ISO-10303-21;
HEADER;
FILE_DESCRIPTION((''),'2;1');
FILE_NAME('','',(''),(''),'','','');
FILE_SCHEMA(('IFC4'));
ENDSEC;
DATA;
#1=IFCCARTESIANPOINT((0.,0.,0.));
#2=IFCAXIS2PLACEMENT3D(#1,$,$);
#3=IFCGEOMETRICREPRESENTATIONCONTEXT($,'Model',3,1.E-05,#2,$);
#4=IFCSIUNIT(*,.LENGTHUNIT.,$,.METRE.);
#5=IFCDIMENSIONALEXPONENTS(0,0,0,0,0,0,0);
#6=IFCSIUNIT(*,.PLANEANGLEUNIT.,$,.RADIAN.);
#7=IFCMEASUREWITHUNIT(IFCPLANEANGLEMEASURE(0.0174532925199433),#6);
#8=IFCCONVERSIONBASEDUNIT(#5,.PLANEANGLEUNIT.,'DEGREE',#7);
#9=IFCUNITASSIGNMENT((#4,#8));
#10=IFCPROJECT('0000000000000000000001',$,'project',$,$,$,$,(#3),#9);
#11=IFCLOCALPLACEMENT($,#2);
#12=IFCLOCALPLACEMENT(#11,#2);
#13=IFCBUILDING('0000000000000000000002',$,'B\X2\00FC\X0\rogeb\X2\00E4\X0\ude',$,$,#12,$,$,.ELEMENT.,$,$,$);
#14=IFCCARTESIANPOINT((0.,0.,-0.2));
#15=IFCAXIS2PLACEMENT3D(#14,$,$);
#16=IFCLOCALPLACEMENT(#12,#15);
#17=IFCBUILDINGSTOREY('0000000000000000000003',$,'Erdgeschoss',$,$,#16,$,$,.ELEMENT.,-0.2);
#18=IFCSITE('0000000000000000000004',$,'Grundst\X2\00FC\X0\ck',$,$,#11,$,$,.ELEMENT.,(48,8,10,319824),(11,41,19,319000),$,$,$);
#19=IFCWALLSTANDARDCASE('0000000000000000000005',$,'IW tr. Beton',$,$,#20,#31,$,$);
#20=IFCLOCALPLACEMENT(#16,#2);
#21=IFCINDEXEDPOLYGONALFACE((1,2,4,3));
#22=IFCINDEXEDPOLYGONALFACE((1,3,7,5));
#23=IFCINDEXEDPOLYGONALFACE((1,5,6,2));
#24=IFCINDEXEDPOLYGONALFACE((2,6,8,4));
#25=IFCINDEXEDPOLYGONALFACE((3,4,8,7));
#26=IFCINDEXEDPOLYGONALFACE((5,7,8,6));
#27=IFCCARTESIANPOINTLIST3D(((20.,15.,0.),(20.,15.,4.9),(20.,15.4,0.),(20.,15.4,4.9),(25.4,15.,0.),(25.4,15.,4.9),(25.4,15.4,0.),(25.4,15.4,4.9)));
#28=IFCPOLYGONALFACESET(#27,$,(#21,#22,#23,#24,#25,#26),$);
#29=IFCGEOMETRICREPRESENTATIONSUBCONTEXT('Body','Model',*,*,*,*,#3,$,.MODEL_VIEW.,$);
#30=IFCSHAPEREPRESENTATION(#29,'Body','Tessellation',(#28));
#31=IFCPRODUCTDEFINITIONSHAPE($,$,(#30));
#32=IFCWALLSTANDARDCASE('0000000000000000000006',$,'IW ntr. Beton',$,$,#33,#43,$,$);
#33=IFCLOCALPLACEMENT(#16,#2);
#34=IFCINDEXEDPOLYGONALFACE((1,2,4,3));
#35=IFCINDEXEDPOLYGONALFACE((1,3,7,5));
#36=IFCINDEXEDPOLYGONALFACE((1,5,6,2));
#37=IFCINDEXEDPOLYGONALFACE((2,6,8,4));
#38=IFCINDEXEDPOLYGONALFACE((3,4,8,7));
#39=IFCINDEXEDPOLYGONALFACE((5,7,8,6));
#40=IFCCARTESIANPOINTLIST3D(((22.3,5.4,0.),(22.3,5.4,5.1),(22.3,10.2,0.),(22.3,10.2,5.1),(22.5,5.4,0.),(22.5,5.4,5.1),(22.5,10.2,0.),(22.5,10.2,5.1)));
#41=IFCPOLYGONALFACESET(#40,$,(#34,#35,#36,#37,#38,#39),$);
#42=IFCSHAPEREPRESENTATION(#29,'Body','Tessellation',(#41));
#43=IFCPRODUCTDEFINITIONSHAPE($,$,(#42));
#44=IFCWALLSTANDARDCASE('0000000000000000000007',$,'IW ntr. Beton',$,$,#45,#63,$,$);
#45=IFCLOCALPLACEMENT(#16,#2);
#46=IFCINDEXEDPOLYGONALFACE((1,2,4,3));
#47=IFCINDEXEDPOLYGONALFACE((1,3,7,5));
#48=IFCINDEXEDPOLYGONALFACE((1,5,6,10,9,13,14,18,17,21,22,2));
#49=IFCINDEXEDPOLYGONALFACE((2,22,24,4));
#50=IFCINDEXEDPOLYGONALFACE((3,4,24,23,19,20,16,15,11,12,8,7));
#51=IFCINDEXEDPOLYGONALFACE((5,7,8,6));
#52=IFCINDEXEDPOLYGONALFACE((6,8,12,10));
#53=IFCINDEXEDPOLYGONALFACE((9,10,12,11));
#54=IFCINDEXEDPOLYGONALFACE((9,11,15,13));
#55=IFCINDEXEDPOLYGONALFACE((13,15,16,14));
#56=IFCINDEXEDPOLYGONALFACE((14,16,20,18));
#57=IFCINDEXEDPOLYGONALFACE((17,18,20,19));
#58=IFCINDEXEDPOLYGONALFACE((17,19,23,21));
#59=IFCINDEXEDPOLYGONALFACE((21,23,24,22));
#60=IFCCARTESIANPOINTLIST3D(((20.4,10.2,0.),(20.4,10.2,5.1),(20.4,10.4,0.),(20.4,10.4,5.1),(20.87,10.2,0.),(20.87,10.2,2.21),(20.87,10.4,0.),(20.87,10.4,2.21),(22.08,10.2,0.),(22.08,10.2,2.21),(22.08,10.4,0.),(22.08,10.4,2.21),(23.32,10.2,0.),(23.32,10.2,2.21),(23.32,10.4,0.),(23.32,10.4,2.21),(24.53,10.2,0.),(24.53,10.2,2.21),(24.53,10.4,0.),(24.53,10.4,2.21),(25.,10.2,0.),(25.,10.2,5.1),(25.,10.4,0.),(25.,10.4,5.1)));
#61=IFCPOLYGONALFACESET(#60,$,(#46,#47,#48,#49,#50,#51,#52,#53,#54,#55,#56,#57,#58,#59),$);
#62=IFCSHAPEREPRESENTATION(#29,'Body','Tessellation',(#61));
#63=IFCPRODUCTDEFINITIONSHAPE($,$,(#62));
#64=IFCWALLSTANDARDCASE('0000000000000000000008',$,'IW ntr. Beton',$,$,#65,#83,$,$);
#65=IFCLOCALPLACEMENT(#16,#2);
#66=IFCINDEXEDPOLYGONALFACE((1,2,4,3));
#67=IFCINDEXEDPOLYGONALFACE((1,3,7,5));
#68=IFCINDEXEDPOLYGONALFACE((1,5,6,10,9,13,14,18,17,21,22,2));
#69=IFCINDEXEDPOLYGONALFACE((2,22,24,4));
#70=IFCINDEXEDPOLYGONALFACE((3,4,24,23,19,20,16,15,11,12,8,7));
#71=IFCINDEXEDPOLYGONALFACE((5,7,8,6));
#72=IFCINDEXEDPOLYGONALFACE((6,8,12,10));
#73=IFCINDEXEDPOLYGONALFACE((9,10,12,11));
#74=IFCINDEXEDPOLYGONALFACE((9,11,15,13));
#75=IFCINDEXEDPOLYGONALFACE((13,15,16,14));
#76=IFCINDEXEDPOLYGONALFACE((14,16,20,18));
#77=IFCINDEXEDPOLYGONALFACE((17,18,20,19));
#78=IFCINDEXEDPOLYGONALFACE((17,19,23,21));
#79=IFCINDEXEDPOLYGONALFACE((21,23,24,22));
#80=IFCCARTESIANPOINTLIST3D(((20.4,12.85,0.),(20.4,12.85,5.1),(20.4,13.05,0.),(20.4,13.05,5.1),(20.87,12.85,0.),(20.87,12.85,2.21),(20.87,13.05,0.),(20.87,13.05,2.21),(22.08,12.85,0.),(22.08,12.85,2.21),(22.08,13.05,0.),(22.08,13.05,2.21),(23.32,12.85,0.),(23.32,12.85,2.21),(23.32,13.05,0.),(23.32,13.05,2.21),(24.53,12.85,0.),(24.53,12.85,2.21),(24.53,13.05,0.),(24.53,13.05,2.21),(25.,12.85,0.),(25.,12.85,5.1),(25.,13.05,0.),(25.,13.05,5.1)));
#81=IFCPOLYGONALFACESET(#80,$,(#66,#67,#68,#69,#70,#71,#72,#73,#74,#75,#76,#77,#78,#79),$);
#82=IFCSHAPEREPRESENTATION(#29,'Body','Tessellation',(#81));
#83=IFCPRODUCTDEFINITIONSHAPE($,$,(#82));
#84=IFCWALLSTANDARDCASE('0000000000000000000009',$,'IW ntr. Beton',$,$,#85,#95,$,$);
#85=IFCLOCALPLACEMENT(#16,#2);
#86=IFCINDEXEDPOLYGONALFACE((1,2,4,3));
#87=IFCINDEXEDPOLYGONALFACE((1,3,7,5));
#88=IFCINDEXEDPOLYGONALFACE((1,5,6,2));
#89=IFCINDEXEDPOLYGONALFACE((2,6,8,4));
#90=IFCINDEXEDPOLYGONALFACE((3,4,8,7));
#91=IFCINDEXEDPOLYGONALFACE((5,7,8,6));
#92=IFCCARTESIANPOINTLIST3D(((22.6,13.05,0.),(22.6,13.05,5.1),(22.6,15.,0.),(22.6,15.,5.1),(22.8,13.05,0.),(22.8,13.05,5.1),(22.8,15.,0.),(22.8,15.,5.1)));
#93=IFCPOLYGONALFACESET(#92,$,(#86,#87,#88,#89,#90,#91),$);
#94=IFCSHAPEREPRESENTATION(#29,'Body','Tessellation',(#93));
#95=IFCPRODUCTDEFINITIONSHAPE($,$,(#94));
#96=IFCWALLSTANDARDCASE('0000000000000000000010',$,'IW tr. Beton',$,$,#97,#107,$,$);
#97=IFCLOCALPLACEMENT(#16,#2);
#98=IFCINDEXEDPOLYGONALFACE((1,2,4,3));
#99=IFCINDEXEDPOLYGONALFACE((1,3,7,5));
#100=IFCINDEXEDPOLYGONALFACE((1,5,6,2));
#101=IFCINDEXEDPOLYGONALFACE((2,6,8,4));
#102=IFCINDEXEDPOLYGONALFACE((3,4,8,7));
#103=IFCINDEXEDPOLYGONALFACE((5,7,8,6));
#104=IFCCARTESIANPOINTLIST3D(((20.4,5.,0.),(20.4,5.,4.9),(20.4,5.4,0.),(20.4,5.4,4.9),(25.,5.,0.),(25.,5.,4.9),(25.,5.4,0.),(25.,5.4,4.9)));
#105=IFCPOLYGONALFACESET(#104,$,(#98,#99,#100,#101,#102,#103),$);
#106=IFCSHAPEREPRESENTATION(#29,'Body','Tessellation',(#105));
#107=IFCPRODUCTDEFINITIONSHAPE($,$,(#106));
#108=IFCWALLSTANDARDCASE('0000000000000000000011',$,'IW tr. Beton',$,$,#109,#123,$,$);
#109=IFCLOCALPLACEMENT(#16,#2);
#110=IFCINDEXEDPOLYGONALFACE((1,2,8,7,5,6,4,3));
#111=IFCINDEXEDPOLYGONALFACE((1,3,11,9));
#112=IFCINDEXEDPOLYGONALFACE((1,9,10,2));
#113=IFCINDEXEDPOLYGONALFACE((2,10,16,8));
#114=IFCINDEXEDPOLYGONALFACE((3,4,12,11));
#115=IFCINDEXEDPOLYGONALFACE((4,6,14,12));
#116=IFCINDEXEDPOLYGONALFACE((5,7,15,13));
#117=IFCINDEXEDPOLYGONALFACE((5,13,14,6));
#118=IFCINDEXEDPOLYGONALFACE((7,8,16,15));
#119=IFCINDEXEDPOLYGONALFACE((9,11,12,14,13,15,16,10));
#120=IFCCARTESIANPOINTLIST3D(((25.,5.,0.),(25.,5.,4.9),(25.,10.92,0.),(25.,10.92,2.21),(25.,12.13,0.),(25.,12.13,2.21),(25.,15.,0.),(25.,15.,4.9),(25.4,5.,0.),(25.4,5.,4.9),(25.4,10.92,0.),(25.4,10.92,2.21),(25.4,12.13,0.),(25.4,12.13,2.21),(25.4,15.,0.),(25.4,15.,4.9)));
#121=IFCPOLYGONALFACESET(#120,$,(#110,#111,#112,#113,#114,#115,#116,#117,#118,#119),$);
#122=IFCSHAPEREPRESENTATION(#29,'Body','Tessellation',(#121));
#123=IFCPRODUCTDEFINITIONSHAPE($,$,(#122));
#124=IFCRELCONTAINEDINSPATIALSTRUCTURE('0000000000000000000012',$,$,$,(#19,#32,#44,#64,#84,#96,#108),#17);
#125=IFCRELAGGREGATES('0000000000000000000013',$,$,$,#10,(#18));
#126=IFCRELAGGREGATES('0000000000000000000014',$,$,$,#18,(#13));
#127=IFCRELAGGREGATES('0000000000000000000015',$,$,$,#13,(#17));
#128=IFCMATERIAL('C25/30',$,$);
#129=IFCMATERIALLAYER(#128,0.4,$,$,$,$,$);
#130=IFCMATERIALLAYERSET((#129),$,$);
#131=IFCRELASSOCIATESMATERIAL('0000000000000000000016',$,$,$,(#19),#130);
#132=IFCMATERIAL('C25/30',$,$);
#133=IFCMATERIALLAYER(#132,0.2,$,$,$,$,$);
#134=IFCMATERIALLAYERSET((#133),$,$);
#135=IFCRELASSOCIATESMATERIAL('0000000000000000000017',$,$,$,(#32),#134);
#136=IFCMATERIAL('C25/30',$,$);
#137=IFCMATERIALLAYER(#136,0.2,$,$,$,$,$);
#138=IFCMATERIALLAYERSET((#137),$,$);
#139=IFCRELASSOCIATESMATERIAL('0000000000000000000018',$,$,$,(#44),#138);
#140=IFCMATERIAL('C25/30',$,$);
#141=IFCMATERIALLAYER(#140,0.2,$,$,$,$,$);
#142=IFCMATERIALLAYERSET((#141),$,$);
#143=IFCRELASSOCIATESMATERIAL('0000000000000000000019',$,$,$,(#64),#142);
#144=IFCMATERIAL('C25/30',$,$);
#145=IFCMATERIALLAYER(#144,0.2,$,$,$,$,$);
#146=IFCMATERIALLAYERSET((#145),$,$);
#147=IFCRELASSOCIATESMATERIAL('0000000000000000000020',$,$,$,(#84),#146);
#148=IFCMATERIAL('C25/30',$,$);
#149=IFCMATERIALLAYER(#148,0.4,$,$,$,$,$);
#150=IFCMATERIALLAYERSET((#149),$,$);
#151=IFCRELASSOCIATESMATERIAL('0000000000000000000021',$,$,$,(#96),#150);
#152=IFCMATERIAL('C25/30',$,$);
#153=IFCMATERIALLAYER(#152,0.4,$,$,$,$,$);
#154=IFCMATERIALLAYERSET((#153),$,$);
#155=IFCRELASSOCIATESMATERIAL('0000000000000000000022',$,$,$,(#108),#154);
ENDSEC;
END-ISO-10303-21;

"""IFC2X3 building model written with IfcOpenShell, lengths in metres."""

from ifc_helpers import new_model, entity, si_unit, converted_unit, frame, frame_2d, origin, origin_with_axes, place, context, subcontext, project, spatial, polyline, rectangle, outline, extrude, material, layer, layer_set, layer_usage, element, save


model = new_model("IFC2X3")

# Units and contexts
model_context = context("Model", 3, precision=1e-05, world=origin())
body_context = subcontext(model_context, "Body", "Model", "MODEL_VIEW")
ifc_project = project(units=[si_unit("LENGTHUNIT", "METRE"), converted_unit("PLANEANGLEUNIT", "DEGREE", entity("IfcPlaneAngleMeasure", 0.0174532925199433), si_unit("PLANEANGLEUNIT", "RADIAN"), dimensions=[0, 0, 0, 0, 0, 0, 0])], contexts=[model_context])

# Site, building, storey
site_placement = place(None, origin())
site = spatial("IfcSite", under=ifc_project, at=site_placement, Name="Grundstück", CompositionType="ELEMENT", RefLatitude=(48, 8, 10, 319824), RefLongitude=(11, 41, 19, 319000))
building_placement = place(site_placement, origin())
building = spatial("IfcBuilding", under=site, at=building_placement, Name="Bürogebäude", CompositionType="ELEMENT")
storey_placement = place(building_placement, frame((0.0, 0.0, -0.2)))
storey = spatial("IfcBuildingStorey", under=building, at=storey_placement, Name="Erdgeschoss", CompositionType="ELEMENT", Elevation=-0.2)

# Walls
ifc_material_1 = material(Name="C25/30")
ifc_layer_1 = layer(ifc_material_1, 0.4)
ifc_layer_set_1 = layer_set([ifc_layer_1])
ifc_layer_usage_1 = layer_usage(ifc_layer_set_1, "AXIS2", "POSITIVE", -0.2)
wall_1_placement = place(storey_placement, frame((20.0, 15.0, 0.0)))
element("IfcWallStandardCase", 1, at=wall_1_placement, inside=storey, material=ifc_layer_usage_1, Name="IW tr. Beton", context=body_context, shape_type="SweptSolid", body=[
    extrude(rectangle(XDim=5.4, YDim=0.4, at=frame_2d((2.7, 0.2), x_axis=(1.0, 0.0))), origin_with_axes(), (0.0, 0.0, 1.0), 4.9),
])
ifc_material_2 = material(Name="C25/30")
ifc_layer_2 = layer(ifc_material_2, 0.2)
ifc_layer_set_2 = layer_set([ifc_layer_2])
ifc_layer_usage_2 = layer_usage(ifc_layer_set_2, "AXIS2", "POSITIVE", -0.2)
wall_2_placement = place(storey_placement, frame((22.3, 10.2, 0.0), z_axis=(0.0, 0.0, 1.0), x_axis=(0.0, -1.0, 0.0)))
element("IfcWallStandardCase", 2, at=wall_2_placement, inside=storey, material=ifc_layer_usage_2, Name="IW ntr. Beton", context=body_context, shape_type="SweptSolid", body=[
    extrude(rectangle(XDim=4.8, YDim=0.2, at=frame_2d((2.4, 0.1), x_axis=(1.0, 0.0))), origin_with_axes(), (0.0, 0.0, 1.0), 5.1),
])

# Walls, openings
ifc_material_3 = material(Name="C25/30")
ifc_layer_3 = layer(ifc_material_3, 0.2)
ifc_layer_set_3 = layer_set([ifc_layer_3])
ifc_layer_usage_3 = layer_usage(ifc_layer_set_3, "AXIS2", "POSITIVE", -0.2)
wall_3_placement = place(storey_placement, frame((25.0, 10.4, 0.0), z_axis=(0.0, 0.0, 1.0), x_axis=(-1.0, 0.0, 0.0)))
wall_3 = element("IfcWallStandardCase", 3, at=wall_3_placement, inside=storey, material=ifc_layer_usage_3, Name="IW ntr. Beton", context=body_context, shape_type="SweptSolid", body=[
    extrude(rectangle(XDim=4.6, YDim=0.2, at=frame_2d((2.3, 0.1), x_axis=(1.0, 0.0))), origin_with_axes(), (0.0, 0.0, 1.0), 5.1),
])
opening_1_placement = place(wall_3_placement, frame((1.68, 0.2, 0.0), z_axis=(0.0, -1.0, 0.0), x_axis=(0.0, 0.0, 1.0)))
element("IfcOpeningElement", 4, at=opening_1_placement, cuts=wall_3, ObjectType="Opening", context=body_context, shape_type="SweptSolid", body=[
    extrude(outline(polyline([(0.0, 1.21), (2.21, 1.21), (2.21, 0.0), (0.0, 0.0), (0.0, 1.21)])), origin_with_axes(), (0.0, 0.0, 1.0), 0.2),
])
opening_2_placement = place(wall_3_placement, frame((4.13, 0.2, 0.0), z_axis=(0.0, -1.0, 0.0), x_axis=(0.0, 0.0, 1.0)))
element("IfcOpeningElement", 5, at=opening_2_placement, cuts=wall_3, ObjectType="Opening", context=body_context, shape_type="SweptSolid", body=[
    extrude(outline(polyline([(0.0, 1.21), (2.21, 1.21), (2.21, 0.0), (0.0, 0.0), (0.0, 1.21)])), origin_with_axes(), (0.0, 0.0, 1.0), 0.2),
])
ifc_material_4 = material(Name="C25/30")
ifc_layer_4 = layer(ifc_material_4, 0.2)
ifc_layer_set_4 = layer_set([ifc_layer_4])
ifc_layer_usage_4 = layer_usage(ifc_layer_set_4, "AXIS2", "POSITIVE", -0.2)
wall_4_placement = place(storey_placement, frame((25.0, 13.05, 0.0), z_axis=(0.0, 0.0, 1.0), x_axis=(-1.0, 0.0, 0.0)))
wall_4 = element("IfcWallStandardCase", 6, at=wall_4_placement, inside=storey, material=ifc_layer_usage_4, Name="IW ntr. Beton", context=body_context, shape_type="SweptSolid", body=[
    extrude(rectangle(XDim=4.6, YDim=0.2, at=frame_2d((2.3, 0.1), x_axis=(1.0, 0.0))), origin_with_axes(), (0.0, 0.0, 1.0), 5.1),
])
opening_3_placement = place(wall_4_placement, frame((4.13, 0.2, 0.0), z_axis=(0.0, -1.0, 0.0), x_axis=(0.0, 0.0, 1.0)))
element("IfcOpeningElement", 7, at=opening_3_placement, cuts=wall_4, ObjectType="Opening", context=body_context, shape_type="SweptSolid", body=[
    extrude(outline(polyline([(0.0, 1.21), (2.21, 1.21), (2.21, 0.0), (0.0, 0.0), (0.0, 1.21)])), origin_with_axes(), (0.0, 0.0, 1.0), 0.2),
])
opening_4_placement = place(wall_4_placement, frame((1.68, 0.2, 0.0), z_axis=(0.0, -1.0, 0.0), x_axis=(0.0, 0.0, 1.0)))
element("IfcOpeningElement", 8, at=opening_4_placement, cuts=wall_4, ObjectType="Opening", context=body_context, shape_type="SweptSolid", body=[
    extrude(outline(polyline([(0.0, 1.21), (2.21, 1.21), (2.21, 0.0), (0.0, 0.0), (0.0, 1.21)])), origin_with_axes(), (0.0, 0.0, 1.0), 0.2),
])

# Walls
ifc_material_5 = material(Name="C25/30")
ifc_layer_5 = layer(ifc_material_5, 0.2)
ifc_layer_set_5 = layer_set([ifc_layer_5])
ifc_layer_usage_5 = layer_usage(ifc_layer_set_5, "AXIS2", "POSITIVE", -0.2)
wall_5_placement = place(storey_placement, frame((22.6, 15.0, 0.0), z_axis=(0.0, 0.0, 1.0), x_axis=(0.0, -1.0, 0.0)))
element("IfcWallStandardCase", 9, at=wall_5_placement, inside=storey, material=ifc_layer_usage_5, Name="IW ntr. Beton", context=body_context, shape_type="SweptSolid", body=[
    extrude(rectangle(XDim=1.95, YDim=0.2, at=frame_2d((0.975, 0.1), x_axis=(1.0, 0.0))), origin_with_axes(), (0.0, 0.0, 1.0), 5.1),
])
ifc_material_6 = material(Name="C25/30")
ifc_layer_6 = layer(ifc_material_6, 0.4)
ifc_layer_set_6 = layer_set([ifc_layer_6])
ifc_layer_usage_6 = layer_usage(ifc_layer_set_6, "AXIS2", "POSITIVE", -0.2)
wall_6_placement = place(storey_placement, frame((25.0, 5.4, 0.0), z_axis=(0.0, 0.0, 1.0), x_axis=(-1.0, 0.0, 0.0)))
element("IfcWallStandardCase", 10, at=wall_6_placement, inside=storey, material=ifc_layer_usage_6, Name="IW tr. Beton", context=body_context, shape_type="SweptSolid", body=[
    extrude(rectangle(XDim=4.6, YDim=0.4, at=frame_2d((2.3, 0.2), x_axis=(1.0, 0.0))), origin_with_axes(), (0.0, 0.0, 1.0), 4.9),
])

# Wall, opening
ifc_material_7 = material(Name="C25/30")
ifc_layer_7 = layer(ifc_material_7, 0.4)
ifc_layer_set_7 = layer_set([ifc_layer_7])
ifc_layer_usage_7 = layer_usage(ifc_layer_set_7, "AXIS2", "POSITIVE", -0.2)
wall_7_placement = place(storey_placement, frame((25.0, 15.0, 0.0), z_axis=(0.0, 0.0, 1.0), x_axis=(0.0, -1.0, 0.0)))
wall_7 = element("IfcWallStandardCase", 11, at=wall_7_placement, inside=storey, material=ifc_layer_usage_7, Name="IW tr. Beton", context=body_context, shape_type="SweptSolid", body=[
    extrude(rectangle(XDim=10.0, YDim=0.4, at=frame_2d((5.0, 0.2), x_axis=(1.0, 0.0))), origin_with_axes(), (0.0, 0.0, 1.0), 4.9),
])
opening_5_placement = place(wall_7_placement, frame((4.08, 0.4, 0.0), z_axis=(0.0, -1.0, 0.0), x_axis=(0.0, 0.0, 1.0)))
element("IfcOpeningElement", 12, at=opening_5_placement, cuts=wall_7, ObjectType="Opening", context=body_context, shape_type="SweptSolid", body=[
    extrude(outline(polyline([(0.0, 1.21), (2.21, 1.21), (2.21, 0.0), (0.0, 0.0), (0.0, 1.21)])), origin_with_axes(), (0.0, 0.0, 1.0), 0.4),
])

save(model, "model.ifc")
